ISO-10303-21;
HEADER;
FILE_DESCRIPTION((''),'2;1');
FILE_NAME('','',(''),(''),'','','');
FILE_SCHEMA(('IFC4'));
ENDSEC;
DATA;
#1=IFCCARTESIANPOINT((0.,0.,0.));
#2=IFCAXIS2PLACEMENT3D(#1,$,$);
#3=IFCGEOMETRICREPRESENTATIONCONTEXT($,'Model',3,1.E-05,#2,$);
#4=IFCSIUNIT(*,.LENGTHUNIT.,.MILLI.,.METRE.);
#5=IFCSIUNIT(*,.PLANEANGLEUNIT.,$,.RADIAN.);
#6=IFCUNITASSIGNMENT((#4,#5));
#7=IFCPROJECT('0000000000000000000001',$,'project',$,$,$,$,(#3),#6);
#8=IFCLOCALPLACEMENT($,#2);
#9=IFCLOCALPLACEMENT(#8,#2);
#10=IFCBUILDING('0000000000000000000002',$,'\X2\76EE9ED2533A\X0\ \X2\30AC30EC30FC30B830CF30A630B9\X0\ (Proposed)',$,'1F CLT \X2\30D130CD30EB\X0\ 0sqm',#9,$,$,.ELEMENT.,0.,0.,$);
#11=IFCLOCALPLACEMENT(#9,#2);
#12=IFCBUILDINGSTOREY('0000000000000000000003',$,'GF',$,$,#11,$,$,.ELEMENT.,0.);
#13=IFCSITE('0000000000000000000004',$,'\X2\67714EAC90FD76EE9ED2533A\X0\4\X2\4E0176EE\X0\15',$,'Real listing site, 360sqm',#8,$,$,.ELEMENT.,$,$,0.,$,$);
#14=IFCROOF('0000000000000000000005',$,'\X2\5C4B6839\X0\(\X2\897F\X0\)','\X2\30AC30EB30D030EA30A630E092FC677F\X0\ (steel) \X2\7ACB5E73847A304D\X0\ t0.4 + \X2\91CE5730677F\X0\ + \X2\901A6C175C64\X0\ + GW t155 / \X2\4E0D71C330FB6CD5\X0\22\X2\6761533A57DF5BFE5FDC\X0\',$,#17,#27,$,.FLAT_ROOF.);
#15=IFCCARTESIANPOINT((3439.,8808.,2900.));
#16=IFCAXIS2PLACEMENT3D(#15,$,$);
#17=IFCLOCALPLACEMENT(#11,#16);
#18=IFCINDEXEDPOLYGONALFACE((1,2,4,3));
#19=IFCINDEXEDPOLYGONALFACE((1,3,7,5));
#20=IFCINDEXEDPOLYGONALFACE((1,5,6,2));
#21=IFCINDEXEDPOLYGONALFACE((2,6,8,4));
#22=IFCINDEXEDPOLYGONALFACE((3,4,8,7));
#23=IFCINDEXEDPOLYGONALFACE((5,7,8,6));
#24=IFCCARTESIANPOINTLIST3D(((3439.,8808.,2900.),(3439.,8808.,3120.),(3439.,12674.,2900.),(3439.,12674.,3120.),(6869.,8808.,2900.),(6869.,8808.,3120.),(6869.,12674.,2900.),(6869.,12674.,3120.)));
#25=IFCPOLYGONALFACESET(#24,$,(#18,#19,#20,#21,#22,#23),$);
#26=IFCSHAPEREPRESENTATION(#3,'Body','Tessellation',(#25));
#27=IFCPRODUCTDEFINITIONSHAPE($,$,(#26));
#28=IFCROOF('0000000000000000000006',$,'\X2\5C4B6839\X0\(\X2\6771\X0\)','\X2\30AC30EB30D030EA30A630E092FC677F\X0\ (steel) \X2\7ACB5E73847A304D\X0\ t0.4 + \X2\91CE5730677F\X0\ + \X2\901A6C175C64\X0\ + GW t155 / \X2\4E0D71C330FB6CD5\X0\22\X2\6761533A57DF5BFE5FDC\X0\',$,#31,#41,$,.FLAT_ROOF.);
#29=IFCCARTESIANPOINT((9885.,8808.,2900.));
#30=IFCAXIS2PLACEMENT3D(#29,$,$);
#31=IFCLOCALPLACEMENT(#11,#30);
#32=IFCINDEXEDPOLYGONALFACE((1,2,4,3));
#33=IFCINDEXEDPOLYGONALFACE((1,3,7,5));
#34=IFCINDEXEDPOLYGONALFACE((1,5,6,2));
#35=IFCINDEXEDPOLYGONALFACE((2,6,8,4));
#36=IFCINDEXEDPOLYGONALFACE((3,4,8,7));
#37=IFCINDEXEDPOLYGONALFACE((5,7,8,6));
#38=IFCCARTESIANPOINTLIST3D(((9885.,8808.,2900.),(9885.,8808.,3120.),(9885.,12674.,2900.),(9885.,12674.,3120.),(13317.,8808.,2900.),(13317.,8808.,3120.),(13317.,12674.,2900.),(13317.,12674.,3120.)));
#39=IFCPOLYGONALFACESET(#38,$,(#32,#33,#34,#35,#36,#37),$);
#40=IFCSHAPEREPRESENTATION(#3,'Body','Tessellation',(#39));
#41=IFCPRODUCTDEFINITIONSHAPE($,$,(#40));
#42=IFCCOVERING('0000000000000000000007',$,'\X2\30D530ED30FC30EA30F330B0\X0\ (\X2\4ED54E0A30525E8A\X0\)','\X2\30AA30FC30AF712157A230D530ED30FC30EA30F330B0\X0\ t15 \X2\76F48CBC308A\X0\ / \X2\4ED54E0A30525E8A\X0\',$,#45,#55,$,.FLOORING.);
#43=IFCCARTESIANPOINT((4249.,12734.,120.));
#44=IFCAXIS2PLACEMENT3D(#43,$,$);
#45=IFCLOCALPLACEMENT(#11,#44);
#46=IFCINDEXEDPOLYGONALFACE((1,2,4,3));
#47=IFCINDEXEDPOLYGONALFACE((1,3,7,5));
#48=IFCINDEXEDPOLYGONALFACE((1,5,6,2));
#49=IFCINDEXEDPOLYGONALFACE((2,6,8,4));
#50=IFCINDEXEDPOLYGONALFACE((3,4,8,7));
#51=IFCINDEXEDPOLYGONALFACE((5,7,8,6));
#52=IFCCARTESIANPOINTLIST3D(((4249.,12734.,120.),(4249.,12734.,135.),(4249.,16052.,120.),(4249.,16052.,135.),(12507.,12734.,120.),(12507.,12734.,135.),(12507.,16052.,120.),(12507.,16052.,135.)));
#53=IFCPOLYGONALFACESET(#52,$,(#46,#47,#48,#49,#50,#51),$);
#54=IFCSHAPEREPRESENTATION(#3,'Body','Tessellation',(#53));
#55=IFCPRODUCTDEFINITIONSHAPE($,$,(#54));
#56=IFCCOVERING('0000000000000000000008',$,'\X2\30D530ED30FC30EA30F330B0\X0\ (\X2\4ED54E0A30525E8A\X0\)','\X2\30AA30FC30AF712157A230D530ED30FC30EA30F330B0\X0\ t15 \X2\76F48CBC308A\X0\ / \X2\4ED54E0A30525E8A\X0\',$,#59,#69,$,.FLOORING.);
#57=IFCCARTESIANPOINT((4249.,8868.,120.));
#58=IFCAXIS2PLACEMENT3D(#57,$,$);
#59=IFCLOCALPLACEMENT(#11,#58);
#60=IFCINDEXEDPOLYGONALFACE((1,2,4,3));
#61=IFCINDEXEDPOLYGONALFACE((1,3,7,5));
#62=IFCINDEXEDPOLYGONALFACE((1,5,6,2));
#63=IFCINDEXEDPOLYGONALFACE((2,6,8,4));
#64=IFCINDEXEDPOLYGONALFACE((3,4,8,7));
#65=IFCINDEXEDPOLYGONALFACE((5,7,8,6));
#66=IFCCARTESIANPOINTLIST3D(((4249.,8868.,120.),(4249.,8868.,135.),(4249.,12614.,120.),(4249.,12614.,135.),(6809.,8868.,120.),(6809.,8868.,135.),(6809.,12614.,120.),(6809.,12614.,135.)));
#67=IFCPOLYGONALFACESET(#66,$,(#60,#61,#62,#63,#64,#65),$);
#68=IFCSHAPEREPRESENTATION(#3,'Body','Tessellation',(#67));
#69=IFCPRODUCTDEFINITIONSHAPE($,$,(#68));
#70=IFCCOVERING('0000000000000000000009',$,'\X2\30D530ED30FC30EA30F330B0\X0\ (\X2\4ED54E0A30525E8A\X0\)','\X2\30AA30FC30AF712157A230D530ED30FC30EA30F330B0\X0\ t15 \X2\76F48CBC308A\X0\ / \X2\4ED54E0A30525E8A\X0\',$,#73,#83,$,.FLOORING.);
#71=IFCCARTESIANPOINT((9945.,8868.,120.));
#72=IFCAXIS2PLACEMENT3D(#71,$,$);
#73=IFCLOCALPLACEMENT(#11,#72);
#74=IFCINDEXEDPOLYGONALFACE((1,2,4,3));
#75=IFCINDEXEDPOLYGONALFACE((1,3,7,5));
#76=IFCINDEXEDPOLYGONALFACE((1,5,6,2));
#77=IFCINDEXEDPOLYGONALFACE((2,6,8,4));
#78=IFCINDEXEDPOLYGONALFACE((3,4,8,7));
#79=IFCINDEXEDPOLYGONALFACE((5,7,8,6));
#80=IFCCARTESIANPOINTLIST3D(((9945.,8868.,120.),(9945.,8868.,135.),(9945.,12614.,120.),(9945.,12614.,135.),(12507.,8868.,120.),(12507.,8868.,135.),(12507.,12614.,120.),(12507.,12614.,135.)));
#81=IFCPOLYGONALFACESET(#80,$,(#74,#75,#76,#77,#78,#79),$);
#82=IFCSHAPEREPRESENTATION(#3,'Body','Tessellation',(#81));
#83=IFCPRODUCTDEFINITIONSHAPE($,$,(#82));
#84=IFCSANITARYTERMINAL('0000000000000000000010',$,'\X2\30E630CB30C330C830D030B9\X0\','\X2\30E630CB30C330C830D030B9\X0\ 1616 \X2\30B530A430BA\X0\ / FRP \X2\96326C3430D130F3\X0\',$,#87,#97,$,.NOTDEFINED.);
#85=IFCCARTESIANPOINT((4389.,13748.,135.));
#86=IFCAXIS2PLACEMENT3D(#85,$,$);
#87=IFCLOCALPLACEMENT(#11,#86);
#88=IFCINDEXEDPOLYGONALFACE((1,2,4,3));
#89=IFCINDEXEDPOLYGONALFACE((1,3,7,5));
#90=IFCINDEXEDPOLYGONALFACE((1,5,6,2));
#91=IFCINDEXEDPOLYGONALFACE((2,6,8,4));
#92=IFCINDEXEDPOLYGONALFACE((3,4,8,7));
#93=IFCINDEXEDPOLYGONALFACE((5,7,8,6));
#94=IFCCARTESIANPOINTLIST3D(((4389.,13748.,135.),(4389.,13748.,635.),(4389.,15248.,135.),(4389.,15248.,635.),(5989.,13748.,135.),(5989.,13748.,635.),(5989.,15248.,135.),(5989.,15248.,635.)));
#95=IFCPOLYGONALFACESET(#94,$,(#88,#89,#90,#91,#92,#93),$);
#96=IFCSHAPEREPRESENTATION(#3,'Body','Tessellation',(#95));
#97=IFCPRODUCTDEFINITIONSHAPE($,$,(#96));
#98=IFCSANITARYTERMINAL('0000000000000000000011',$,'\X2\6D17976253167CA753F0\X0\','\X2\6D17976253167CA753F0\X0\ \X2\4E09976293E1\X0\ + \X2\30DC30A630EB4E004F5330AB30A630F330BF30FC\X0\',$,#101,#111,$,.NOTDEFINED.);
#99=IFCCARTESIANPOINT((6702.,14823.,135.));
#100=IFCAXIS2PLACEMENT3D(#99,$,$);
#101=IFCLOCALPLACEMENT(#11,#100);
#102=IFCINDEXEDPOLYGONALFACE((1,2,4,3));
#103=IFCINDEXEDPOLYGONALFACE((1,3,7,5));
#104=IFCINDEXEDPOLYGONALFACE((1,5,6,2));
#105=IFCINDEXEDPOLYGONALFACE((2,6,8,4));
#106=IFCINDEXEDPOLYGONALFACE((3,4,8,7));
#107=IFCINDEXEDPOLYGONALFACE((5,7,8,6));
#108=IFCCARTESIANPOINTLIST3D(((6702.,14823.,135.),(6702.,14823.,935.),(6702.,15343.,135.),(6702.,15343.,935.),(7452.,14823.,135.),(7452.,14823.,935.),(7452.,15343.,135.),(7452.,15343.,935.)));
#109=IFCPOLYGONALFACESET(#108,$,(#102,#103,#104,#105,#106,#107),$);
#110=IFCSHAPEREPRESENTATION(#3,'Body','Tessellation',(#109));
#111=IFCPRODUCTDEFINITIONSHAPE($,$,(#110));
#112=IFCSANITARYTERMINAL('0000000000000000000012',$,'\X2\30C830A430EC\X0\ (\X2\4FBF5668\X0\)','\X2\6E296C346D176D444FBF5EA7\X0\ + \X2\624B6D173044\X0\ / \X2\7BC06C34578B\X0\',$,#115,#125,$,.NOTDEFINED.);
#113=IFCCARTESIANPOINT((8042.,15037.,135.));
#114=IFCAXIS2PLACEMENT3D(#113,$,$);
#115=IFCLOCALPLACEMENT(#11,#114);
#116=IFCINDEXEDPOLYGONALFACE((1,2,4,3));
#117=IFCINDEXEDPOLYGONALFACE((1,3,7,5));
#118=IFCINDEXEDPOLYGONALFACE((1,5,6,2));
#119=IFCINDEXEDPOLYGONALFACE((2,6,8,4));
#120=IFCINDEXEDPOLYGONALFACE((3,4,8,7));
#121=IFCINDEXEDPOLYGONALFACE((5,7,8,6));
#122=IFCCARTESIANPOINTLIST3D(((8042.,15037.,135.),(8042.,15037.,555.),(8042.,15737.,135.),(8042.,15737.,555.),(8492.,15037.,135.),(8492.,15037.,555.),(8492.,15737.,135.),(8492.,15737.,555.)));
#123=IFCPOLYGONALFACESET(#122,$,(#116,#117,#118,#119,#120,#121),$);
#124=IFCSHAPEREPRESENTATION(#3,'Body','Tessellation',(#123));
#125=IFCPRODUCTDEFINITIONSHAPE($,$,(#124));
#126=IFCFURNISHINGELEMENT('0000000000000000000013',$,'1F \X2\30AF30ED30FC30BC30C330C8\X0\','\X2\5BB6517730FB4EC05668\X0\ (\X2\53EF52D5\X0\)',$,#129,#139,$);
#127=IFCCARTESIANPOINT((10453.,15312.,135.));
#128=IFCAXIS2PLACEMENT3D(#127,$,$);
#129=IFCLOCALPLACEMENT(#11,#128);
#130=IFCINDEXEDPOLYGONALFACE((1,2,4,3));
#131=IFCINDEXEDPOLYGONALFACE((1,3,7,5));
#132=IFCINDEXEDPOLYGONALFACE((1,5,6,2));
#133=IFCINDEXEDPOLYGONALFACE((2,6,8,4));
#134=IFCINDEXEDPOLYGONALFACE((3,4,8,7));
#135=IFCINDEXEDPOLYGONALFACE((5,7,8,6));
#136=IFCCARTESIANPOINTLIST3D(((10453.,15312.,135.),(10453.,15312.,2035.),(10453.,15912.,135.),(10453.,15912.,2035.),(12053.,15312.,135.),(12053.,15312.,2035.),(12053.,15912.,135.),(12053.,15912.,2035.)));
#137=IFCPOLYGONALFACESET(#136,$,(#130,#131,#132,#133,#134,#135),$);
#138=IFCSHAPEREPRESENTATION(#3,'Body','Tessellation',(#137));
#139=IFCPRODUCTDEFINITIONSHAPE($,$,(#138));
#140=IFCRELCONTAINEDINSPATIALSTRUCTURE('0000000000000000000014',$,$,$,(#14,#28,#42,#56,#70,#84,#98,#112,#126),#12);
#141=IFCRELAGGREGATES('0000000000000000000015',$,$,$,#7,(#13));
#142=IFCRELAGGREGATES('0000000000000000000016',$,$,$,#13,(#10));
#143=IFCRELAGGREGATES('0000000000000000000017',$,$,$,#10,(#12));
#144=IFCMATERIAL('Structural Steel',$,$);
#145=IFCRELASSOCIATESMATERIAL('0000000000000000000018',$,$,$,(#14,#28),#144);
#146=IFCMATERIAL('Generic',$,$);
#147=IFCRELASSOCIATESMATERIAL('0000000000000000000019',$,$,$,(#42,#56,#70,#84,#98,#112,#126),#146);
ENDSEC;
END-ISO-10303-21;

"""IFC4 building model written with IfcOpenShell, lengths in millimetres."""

from ifc_helpers import new_model, si_unit, frame, frame_2d, origin, place, context, project, spatial, rectangle, extrude, material, element, save


model = new_model("IFC4")

# Units and contexts
model_context = context("Model", 3, precision=1e-05, world=origin())
ifc_project = project(units=[si_unit("LENGTHUNIT", "METRE", prefix="MILLI"), si_unit("PLANEANGLEUNIT", "RADIAN")], contexts=[model_context])

# Site, building, storey
site_placement = place(None, origin())
site = spatial("IfcSite", under=ifc_project, at=site_placement, Name="東京都目黒区4丁目15", ObjectType="Real listing site, 360sqm", CompositionType="ELEMENT", RefElevation=0.0)
building_placement = place(site_placement, origin())
building = spatial("IfcBuilding", under=site, at=building_placement, Name="目黒区 ガレージハウス (Proposed)", ObjectType="1F CLT パネル 0sqm", CompositionType="ELEMENT", ElevationOfRefHeight=0.0, ElevationOfTerrain=0.0)
storey_placement = place(building_placement, origin())
storey = spatial("IfcBuildingStorey", under=building, at=storey_placement, Name="GF", CompositionType="ELEMENT", Elevation=0.0)

# Roofs
ifc_material_1 = material(Name="Structural Steel")
roof_1_placement = place(storey_placement, frame((3439.0, 8808.0, 2900.0)))
element("IfcRoof", 1, at=roof_1_placement, inside=storey, material=ifc_material_1, Name="屋根(西)", Description="ガルバリウム鋼板 (steel) 立平葺き t0.4 + 野地板 + 通気層 + GW t155 / 不燃・法22条区域対応", PredefinedType="FLAT_ROOF", context=model_context, shape_type="SweptSolid", body=[
    extrude(rectangle(XDim=3430.0, YDim=3866.0, at=frame_2d((1715.0, 1933.0))), frame((3439.0, 8808.0, 2900.0)), (0.0, 0.0, 1.0), 220.0),
])
roof_2_placement = place(storey_placement, frame((9885.0, 8808.0, 2900.0)))
element("IfcRoof", 2, at=roof_2_placement, inside=storey, material=ifc_material_1, Name="屋根(東)", Description="ガルバリウム鋼板 (steel) 立平葺き t0.4 + 野地板 + 通気層 + GW t155 / 不燃・法22条区域対応", PredefinedType="FLAT_ROOF", context=model_context, shape_type="SweptSolid", body=[
    extrude(rectangle(XDim=3432.0, YDim=3866.0, at=frame_2d((1716.0, 1933.0))), frame((9885.0, 8808.0, 2900.0)), (0.0, 0.0, 1.0), 220.0),
])

# Coverings
ifc_material_2 = material(Name="Generic")
covering_1_placement = place(storey_placement, frame((4249.0, 12734.0, 120.0)))
element("IfcCovering", 3, at=covering_1_placement, inside=storey, material=ifc_material_2, Name="フローリング (仕上げ床)", Description="オーク無垢フローリング t15 直貼り / 仕上げ床", PredefinedType="FLOORING", context=model_context, shape_type="SweptSolid", body=[
    extrude(rectangle(XDim=8258.0, YDim=3318.0, at=frame_2d((4129.0, 1659.0))), frame((4249.0, 12734.0, 120.0)), (0.0, 0.0, 1.0), 15.0),
])
covering_2_placement = place(storey_placement, frame((4249.0, 8868.0, 120.0)))
element("IfcCovering", 4, at=covering_2_placement, inside=storey, material=ifc_material_2, Name="フローリング (仕上げ床)", Description="オーク無垢フローリング t15 直貼り / 仕上げ床", PredefinedType="FLOORING", context=model_context, shape_type="SweptSolid", body=[
    extrude(rectangle(XDim=2560.0, YDim=3746.0, at=frame_2d((1280.0, 1873.0))), frame((4249.0, 8868.0, 120.0)), (0.0, 0.0, 1.0), 15.0),
])
covering_3_placement = place(storey_placement, frame((9945.0, 8868.0, 120.0)))
element("IfcCovering", 5, at=covering_3_placement, inside=storey, material=ifc_material_2, Name="フローリング (仕上げ床)", Description="オーク無垢フローリング t15 直貼り / 仕上げ床", PredefinedType="FLOORING", context=model_context, shape_type="SweptSolid", body=[
    extrude(rectangle(XDim=2562.0, YDim=3746.0, at=frame_2d((1281.0, 1873.0))), frame((9945.0, 8868.0, 120.0)), (0.0, 0.0, 1.0), 15.0),
])

# Sanitary terminals
sanitary_terminal_1_placement = place(storey_placement, frame((4389.0, 13748.0, 135.0)))
element("IfcSanitaryTerminal", 6, at=sanitary_terminal_1_placement, inside=storey, material=ifc_material_2, Name="ユニットバス", Description="ユニットバス 1616 サイズ / FRP 防水パン", PredefinedType="NOTDEFINED", context=model_context, shape_type="SweptSolid", body=[
    extrude(rectangle(XDim=1600.0, YDim=1500.0, at=frame_2d((800.0, 750.0))), frame((4389.0, 13748.0, 135.0)), (0.0, 0.0, 1.0), 500.0),
])
sanitary_terminal_2_placement = place(storey_placement, frame((6702.0, 14823.0, 135.0)))
element("IfcSanitaryTerminal", 7, at=sanitary_terminal_2_placement, inside=storey, material=ifc_material_2, Name="洗面化粧台", Description="洗面化粧台 三面鏡 + ボウル一体カウンター", PredefinedType="NOTDEFINED", context=model_context, shape_type="SweptSolid", body=[
    extrude(rectangle(XDim=750.0, YDim=520.0, at=frame_2d((375.0, 260.0))), frame((6702.0, 14823.0, 135.0)), (0.0, 0.0, 1.0), 800.0),
])
sanitary_terminal_3_placement = place(storey_placement, frame((8042.0, 15037.0, 135.0)))
element("IfcSanitaryTerminal", 8, at=sanitary_terminal_3_placement, inside=storey, material=ifc_material_2, Name="トイレ (便器)", Description="温水洗浄便座 + 手洗い / 節水型", PredefinedType="NOTDEFINED", context=model_context, shape_type="SweptSolid", body=[
    extrude(rectangle(XDim=450.0, YDim=700.0, at=frame_2d((225.0, 350.0))), frame((8042.0, 15037.0, 135.0)), (0.0, 0.0, 1.0), 420.0),
])

# Furnishing element
furnishing_placement = place(storey_placement, frame((10453.0, 15312.0, 135.0)))
element("IfcFurnishingElement", 9, at=furnishing_placement, inside=storey, material=ifc_material_2, Name="1F クローゼット", Description="家具・什器 (可動)", context=model_context, shape_type="SweptSolid", body=[
    extrude(rectangle(XDim=1600.0, YDim=600.0, at=frame_2d((800.0, 300.0))), frame((10453.0, 15312.0, 135.0)), (0.0, 0.0, 1.0), 1900.0),
])

save(model, "model.ifc")
